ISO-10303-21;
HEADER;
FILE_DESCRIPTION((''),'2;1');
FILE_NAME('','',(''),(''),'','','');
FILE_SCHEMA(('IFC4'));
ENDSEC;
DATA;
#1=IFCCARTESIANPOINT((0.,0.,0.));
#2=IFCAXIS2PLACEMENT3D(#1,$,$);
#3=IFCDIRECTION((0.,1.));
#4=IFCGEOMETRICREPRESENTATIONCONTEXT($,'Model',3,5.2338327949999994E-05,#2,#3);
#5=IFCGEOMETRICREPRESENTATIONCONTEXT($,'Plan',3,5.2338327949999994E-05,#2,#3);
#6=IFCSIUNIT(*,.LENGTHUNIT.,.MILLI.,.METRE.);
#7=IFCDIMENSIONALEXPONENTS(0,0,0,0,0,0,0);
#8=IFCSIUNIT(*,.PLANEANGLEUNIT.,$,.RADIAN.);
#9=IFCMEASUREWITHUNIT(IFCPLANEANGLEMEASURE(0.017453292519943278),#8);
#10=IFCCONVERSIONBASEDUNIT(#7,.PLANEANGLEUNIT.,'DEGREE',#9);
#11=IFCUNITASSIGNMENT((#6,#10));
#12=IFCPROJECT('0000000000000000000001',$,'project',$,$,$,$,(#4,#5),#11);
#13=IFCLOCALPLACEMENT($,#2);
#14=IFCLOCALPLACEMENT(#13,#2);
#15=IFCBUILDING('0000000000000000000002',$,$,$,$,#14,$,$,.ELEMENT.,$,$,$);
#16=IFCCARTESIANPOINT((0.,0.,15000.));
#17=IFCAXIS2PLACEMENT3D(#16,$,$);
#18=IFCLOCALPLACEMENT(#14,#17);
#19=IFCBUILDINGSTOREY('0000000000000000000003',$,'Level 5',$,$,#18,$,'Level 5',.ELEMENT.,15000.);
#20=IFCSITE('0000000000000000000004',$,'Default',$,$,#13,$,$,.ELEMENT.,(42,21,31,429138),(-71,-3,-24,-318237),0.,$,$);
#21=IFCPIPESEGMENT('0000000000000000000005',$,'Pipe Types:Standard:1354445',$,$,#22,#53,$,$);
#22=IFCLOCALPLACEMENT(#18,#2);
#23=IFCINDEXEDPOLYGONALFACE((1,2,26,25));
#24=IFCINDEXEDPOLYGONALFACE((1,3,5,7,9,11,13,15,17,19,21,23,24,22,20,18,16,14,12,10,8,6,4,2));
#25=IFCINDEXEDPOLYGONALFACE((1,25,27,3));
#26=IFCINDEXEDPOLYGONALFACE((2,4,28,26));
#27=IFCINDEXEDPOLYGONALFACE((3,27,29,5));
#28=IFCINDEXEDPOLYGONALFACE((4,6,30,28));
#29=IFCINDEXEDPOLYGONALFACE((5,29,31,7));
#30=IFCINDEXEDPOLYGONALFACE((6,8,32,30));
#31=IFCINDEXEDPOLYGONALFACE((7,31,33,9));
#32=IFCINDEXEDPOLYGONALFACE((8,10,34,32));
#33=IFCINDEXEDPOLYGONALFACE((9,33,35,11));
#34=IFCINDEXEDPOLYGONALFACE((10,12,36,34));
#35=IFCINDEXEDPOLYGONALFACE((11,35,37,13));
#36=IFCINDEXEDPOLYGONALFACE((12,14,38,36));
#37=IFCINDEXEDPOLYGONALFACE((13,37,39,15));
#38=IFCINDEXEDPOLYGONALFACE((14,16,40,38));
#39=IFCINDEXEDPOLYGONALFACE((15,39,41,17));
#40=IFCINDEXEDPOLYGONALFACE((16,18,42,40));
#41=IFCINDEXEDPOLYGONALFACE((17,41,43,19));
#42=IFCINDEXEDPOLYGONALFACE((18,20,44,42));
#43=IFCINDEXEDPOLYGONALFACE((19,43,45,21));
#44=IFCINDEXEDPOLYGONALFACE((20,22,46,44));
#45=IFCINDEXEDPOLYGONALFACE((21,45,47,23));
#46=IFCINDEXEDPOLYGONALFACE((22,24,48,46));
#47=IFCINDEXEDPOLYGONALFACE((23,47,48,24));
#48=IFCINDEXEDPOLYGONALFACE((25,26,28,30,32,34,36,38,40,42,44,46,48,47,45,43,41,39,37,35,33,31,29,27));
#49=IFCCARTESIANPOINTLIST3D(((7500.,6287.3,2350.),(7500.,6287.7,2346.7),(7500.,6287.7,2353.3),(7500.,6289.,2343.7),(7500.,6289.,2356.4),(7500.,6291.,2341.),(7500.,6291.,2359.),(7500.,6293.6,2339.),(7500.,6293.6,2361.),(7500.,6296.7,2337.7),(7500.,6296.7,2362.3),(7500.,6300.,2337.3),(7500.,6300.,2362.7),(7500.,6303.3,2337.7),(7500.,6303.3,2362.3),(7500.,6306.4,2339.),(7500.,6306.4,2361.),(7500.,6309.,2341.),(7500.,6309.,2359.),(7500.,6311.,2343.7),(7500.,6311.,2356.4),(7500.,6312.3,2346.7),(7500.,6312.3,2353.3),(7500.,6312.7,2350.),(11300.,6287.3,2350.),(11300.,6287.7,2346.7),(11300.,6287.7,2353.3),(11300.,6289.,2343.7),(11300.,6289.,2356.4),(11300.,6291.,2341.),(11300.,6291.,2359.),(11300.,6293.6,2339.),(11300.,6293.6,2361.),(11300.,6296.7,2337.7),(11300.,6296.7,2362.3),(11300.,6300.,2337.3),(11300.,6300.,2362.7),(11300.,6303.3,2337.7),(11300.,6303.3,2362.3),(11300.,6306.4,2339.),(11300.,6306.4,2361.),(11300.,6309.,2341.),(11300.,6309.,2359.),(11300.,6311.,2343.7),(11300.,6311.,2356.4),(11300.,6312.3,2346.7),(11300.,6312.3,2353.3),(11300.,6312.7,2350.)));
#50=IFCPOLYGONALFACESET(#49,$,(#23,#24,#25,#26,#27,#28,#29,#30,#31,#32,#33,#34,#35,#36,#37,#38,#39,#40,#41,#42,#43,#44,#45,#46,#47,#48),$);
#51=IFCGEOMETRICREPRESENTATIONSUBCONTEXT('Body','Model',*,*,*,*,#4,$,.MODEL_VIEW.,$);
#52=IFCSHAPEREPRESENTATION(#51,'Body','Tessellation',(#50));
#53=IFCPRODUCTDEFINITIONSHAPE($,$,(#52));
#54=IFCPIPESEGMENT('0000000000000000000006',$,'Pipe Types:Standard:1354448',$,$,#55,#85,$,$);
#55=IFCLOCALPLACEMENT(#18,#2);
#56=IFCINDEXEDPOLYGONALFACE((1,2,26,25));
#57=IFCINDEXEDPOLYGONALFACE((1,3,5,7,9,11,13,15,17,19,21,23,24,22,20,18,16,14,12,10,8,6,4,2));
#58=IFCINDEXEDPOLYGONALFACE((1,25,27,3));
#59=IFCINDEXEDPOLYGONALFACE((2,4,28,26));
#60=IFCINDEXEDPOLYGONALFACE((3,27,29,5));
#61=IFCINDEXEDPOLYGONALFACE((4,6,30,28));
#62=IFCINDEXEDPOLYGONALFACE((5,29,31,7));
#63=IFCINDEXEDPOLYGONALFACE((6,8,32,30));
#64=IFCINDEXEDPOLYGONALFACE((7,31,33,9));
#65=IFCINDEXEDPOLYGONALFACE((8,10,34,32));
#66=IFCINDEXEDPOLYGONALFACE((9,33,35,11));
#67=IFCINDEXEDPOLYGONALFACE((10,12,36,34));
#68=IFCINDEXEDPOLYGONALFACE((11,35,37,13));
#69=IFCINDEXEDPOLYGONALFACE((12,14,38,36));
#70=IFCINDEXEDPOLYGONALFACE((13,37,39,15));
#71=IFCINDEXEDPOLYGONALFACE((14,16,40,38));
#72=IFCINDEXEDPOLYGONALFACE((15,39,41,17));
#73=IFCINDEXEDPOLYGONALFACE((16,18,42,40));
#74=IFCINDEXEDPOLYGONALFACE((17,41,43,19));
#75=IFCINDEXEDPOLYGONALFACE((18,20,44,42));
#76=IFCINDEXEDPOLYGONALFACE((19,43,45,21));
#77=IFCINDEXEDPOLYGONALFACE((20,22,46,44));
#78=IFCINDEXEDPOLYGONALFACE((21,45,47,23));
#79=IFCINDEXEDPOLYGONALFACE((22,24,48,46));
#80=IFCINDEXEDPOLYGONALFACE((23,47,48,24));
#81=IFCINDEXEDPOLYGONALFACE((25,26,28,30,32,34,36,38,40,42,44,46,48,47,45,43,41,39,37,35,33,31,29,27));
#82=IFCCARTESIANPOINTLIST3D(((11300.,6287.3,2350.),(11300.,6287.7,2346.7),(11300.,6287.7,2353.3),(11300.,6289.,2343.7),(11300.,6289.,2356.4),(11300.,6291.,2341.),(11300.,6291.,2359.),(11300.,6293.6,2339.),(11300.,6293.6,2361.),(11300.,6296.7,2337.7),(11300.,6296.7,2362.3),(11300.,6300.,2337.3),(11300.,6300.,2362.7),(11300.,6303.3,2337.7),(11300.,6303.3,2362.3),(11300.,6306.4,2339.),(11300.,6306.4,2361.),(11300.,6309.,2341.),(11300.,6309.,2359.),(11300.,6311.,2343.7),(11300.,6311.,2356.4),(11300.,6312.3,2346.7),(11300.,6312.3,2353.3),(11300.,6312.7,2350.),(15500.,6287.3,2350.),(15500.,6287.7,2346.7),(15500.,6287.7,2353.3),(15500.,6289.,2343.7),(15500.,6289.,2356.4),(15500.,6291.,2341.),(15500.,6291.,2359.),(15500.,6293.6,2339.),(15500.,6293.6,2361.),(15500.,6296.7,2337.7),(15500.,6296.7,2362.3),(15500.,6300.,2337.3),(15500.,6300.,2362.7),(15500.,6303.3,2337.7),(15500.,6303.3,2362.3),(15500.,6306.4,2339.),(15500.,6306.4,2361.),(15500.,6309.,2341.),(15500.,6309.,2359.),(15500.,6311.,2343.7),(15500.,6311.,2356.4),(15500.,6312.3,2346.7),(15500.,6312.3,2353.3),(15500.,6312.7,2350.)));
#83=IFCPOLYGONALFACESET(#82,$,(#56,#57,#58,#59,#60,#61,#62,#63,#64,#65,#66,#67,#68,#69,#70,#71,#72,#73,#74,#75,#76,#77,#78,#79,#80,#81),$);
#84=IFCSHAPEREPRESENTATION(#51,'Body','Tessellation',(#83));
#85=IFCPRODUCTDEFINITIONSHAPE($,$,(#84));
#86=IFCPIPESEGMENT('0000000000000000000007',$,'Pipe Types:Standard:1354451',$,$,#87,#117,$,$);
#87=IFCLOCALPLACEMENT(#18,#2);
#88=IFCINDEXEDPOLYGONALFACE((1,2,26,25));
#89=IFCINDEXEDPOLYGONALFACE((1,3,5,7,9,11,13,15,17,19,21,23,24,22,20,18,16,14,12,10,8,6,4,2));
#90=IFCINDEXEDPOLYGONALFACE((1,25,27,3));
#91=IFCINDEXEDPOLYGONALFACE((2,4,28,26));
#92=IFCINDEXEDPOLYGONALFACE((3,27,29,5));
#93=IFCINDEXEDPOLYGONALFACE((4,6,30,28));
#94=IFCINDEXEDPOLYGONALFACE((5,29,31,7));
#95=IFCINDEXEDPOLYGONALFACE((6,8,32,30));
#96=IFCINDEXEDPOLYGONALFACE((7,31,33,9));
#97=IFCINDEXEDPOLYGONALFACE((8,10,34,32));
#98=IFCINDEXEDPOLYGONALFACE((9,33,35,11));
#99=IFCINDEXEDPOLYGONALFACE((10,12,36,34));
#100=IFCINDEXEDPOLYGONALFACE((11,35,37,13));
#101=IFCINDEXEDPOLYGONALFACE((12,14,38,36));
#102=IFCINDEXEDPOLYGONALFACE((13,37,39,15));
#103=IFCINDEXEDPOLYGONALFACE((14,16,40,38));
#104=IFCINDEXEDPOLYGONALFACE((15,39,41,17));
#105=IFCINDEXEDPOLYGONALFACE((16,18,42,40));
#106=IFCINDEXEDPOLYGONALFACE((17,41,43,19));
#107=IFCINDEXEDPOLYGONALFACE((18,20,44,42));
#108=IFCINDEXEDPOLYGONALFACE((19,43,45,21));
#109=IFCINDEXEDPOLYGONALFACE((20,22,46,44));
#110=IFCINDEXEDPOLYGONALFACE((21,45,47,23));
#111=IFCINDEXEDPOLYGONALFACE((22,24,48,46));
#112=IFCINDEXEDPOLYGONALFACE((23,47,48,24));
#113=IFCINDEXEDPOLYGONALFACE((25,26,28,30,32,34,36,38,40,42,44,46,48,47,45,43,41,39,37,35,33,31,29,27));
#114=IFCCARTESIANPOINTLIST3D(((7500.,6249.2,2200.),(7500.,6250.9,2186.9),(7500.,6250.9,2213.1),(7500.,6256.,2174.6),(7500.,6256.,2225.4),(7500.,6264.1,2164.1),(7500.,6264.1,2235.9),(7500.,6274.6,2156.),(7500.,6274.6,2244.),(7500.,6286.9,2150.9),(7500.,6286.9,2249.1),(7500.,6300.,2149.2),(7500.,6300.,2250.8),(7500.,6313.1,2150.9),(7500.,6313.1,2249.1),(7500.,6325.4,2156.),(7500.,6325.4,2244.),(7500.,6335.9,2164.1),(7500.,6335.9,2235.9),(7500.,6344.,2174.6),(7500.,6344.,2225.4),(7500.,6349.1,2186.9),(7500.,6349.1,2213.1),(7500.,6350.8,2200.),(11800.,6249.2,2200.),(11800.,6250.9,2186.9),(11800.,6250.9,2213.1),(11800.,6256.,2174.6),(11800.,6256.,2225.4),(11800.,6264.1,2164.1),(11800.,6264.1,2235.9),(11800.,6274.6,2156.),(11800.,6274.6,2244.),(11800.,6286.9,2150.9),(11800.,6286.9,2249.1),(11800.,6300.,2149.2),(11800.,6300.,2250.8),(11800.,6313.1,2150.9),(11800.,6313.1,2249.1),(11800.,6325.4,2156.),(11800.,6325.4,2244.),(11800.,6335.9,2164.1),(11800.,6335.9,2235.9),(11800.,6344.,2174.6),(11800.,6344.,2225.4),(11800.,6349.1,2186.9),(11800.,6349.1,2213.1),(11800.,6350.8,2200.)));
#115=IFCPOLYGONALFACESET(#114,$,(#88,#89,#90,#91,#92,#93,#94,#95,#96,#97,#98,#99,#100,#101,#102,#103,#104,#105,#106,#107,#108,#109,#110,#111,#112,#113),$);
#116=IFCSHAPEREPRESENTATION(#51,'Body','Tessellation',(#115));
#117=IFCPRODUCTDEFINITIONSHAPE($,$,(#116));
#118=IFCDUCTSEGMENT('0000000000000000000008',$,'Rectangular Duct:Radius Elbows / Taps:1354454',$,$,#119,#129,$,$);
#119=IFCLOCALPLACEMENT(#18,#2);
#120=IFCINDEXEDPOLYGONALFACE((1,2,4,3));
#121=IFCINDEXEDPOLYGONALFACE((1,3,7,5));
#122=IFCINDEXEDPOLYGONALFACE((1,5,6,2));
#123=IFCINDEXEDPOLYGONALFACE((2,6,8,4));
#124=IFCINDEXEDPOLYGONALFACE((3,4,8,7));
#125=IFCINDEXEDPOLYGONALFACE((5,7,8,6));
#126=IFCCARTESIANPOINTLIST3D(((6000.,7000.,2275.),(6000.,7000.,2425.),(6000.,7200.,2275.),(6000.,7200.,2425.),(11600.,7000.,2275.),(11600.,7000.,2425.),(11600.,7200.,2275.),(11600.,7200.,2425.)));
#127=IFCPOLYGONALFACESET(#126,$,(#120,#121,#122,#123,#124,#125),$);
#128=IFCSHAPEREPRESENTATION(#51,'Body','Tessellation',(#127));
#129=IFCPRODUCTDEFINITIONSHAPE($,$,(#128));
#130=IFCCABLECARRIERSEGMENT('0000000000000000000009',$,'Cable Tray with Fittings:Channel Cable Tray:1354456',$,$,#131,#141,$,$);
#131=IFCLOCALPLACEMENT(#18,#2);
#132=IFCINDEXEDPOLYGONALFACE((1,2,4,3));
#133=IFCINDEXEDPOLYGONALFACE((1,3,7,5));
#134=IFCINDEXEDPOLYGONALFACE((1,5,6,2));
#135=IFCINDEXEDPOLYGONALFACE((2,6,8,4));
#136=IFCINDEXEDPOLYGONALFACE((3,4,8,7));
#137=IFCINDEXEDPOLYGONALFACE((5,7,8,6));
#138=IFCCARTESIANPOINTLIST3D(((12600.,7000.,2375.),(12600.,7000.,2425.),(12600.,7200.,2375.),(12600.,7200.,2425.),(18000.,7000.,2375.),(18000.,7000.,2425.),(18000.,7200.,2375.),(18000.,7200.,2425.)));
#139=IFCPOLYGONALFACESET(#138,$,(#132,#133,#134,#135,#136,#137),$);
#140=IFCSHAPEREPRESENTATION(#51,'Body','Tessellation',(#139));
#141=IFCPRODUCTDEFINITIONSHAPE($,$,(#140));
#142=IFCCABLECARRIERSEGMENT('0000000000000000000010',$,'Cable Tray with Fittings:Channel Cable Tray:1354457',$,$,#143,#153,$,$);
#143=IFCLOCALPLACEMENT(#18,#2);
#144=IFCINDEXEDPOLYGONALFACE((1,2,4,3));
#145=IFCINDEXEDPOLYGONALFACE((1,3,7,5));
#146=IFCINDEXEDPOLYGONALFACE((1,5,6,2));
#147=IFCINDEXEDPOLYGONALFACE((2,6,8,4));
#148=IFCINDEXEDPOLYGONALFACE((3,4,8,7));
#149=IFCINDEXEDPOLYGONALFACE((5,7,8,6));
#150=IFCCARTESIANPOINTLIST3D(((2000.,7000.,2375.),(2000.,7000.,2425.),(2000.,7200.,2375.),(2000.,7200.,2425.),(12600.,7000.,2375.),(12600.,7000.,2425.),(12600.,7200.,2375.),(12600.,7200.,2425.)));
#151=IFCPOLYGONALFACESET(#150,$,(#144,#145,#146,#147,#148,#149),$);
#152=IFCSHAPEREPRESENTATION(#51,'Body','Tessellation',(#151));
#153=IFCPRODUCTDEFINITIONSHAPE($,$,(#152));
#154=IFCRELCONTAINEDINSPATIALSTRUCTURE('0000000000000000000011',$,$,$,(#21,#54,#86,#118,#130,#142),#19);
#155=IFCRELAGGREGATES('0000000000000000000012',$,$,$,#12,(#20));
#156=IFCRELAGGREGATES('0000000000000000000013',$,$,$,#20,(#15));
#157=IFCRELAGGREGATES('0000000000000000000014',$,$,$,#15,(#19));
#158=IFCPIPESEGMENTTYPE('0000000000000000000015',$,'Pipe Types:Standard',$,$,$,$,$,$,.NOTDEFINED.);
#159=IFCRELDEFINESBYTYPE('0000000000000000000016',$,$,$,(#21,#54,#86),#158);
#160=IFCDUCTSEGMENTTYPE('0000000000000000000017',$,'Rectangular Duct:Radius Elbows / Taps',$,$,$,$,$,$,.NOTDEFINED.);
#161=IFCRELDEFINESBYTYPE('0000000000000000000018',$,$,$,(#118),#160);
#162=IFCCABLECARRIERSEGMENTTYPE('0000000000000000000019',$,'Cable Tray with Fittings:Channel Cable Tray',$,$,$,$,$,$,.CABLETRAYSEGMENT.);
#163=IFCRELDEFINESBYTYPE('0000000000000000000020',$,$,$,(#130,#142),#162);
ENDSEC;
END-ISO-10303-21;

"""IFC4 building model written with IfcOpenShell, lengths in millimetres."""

from ifc_helpers import new_model, entity, si_unit, converted_unit, direction, frame, origin, place, context, subcontext, project, spatial, arc, indexed_curve, outline, extrude, type_object, element, save


model = new_model("IFC4")

# Units and contexts
model_context = context("Model", 3, precision=5.2338327949999994e-05, world=origin(), true_north=direction((0.0, 1.0)))
plan_context = context("Plan", 3, precision=5.2338327949999994e-05, world=origin(), true_north=direction((0.0, 1.0)))
body_context = subcontext(model_context, "Body", "Model", "MODEL_VIEW")
ifc_project = project(units=[si_unit("LENGTHUNIT", "METRE", prefix="MILLI"), converted_unit("PLANEANGLEUNIT", "DEGREE", entity("IfcPlaneAngleMeasure", 0.017453292519943278), si_unit("PLANEANGLEUNIT", "RADIAN"), dimensions=[0, 0, 0, 0, 0, 0, 0])], contexts=[model_context, plan_context])

# Site, building, storey
site_placement = place(None, origin())
site = spatial("IfcSite", under=ifc_project, at=site_placement, Name="Default", CompositionType="ELEMENT", RefLatitude=(42, 21, 31, 429138), RefLongitude=(-71, -3, -24, -318237), RefElevation=0.0)
building_placement = place(site_placement, origin())
building = spatial("IfcBuilding", under=site, at=building_placement, CompositionType="ELEMENT")
storey_placement = place(building_placement, frame((0.0, 0.0, 15000.0)))
storey = spatial("IfcBuildingStorey", under=building, at=storey_placement, Name="Level 5", LongName="Level 5", CompositionType="ELEMENT", Elevation=15000.0)

# Pipe segments
pipe_segment_type = type_object("IfcPipeSegmentType", Name="Pipe Types:Standard", PredefinedType="NOTDEFINED")
pipe_segment_1_placement = place(storey_placement, origin())
element("IfcPipeSegment", 1, at=pipe_segment_1_placement, inside=storey, type_object=pipe_segment_type, Name="Pipe Types:Standard:1354445", context=body_context, shape_type="SweptSolid", body=[
    extrude(outline(indexed_curve([(12.7, 0.0), (9.0, 9.0), (0.0, 12.7), (-9.0, 9.0), (-12.7, 0.0), (-9.0, -9.0), (0.0, -12.7), (9.0, -9.0)], segments=[arc(1, 2, 3), arc(3, 4, 5), arc(5, 6, 7), arc(7, 8, 1)], self_intersect=False)), frame((7500.0, 6300.0, 2350.0), z_axis=(1.0, 0.0, 0.0), x_axis=(0.0, 1.0, 0.0)), (0.0, 0.0, 1.0), 3800.0),
])
pipe_segment_2_placement = place(storey_placement, origin())
element("IfcPipeSegment", 2, at=pipe_segment_2_placement, inside=storey, type_object=pipe_segment_type, Name="Pipe Types:Standard:1354448", context=body_context, shape_type="SweptSolid", body=[
    extrude(outline(indexed_curve([(12.7, 0.0), (9.0, 9.0), (0.0, 12.7), (-9.0, 9.0), (-12.7, 0.0), (-9.0, -9.0), (0.0, -12.7), (9.0, -9.0)], segments=[arc(1, 2, 3), arc(3, 4, 5), arc(5, 6, 7), arc(7, 8, 1)], self_intersect=False)), frame((11300.0, 6300.0, 2350.0), z_axis=(1.0, 0.0, 0.0), x_axis=(0.0, -1.0, 0.0)), (0.0, 0.0, 1.0), 4200.0),
])
pipe_segment_3_placement = place(storey_placement, origin())
element("IfcPipeSegment", 3, at=pipe_segment_3_placement, inside=storey, type_object=pipe_segment_type, Name="Pipe Types:Standard:1354451", context=body_context, shape_type="SweptSolid", body=[
    extrude(outline(indexed_curve([(50.8, 0.0), (35.9, 35.9), (0.0, 50.8), (-35.9, 35.9), (-50.8, 0.0), (-35.9, -35.9), (0.0, -50.8), (35.9, -35.9)], segments=[arc(1, 2, 3), arc(3, 4, 5), arc(5, 6, 7), arc(7, 8, 1)], self_intersect=False)), frame((7500.0, 6300.0, 2200.0), z_axis=(1.0, 0.0, 0.0), x_axis=(0.0, 1.0, 0.0)), (0.0, 0.0, 1.0), 4300.0),
])

# Duct segment
duct_segment_type = type_object("IfcDuctSegmentType", Name="Rectangular Duct:Radius Elbows / Taps", PredefinedType="NOTDEFINED")
duct_segment_placement = place(storey_placement, origin())
element("IfcDuctSegment", 4, at=duct_segment_placement, inside=storey, type_object=duct_segment_type, Name="Rectangular Duct:Radius Elbows / Taps:1354454", context=body_context, shape_type="SweptSolid", body=[
    extrude(outline(indexed_curve([(-2800.0, -100.0), (2800.0, -100.0), (2800.0, 100.0), (-2800.0, 100.0), (-2800.0, -100.0)], self_intersect=False)), frame((8800.0, 7100.0, 2275.0), z_axis=(0.0, 0.0, 1.0), x_axis=(-1.0, 0.0, 0.0)), (0.0, 0.0, 1.0), 150.0),
])

# Cable carrier segments
cable_carrier_segment_type = type_object("IfcCableCarrierSegmentType", Name="Cable Tray with Fittings:Channel Cable Tray", PredefinedType="CABLETRAYSEGMENT")
cable_carrier_segment_1_placement = place(storey_placement, origin())
element("IfcCableCarrierSegment", 5, at=cable_carrier_segment_1_placement, inside=storey, type_object=cable_carrier_segment_type, Name="Cable Tray with Fittings:Channel Cable Tray:1354456", context=body_context, shape_type="SweptSolid", body=[
    extrude(outline(indexed_curve([(-2700.0, -100.0), (2700.0, -100.0), (2700.0, 100.0), (-2700.0, 100.0), (-2700.0, -100.0)], self_intersect=False)), frame((15300.0, 7100.0, 2375.0)), (0.0, 0.0, 1.0), 50.0),
])
cable_carrier_segment_2_placement = place(storey_placement, origin())
element("IfcCableCarrierSegment", 6, at=cable_carrier_segment_2_placement, inside=storey, type_object=cable_carrier_segment_type, Name="Cable Tray with Fittings:Channel Cable Tray:1354457", context=body_context, shape_type="SweptSolid", body=[
    extrude(outline(indexed_curve([(-5300.0, -100.0), (5300.0, -100.0), (5300.0, 100.0), (-5300.0, 100.0), (-5300.0, -100.0)], self_intersect=False)), frame((7300.0, 7100.0, 2375.0), z_axis=(0.0, 0.0, 1.0), x_axis=(-1.0, 0.0, 0.0)), (0.0, 0.0, 1.0), 50.0),
])

save(model, "model.ifc")
